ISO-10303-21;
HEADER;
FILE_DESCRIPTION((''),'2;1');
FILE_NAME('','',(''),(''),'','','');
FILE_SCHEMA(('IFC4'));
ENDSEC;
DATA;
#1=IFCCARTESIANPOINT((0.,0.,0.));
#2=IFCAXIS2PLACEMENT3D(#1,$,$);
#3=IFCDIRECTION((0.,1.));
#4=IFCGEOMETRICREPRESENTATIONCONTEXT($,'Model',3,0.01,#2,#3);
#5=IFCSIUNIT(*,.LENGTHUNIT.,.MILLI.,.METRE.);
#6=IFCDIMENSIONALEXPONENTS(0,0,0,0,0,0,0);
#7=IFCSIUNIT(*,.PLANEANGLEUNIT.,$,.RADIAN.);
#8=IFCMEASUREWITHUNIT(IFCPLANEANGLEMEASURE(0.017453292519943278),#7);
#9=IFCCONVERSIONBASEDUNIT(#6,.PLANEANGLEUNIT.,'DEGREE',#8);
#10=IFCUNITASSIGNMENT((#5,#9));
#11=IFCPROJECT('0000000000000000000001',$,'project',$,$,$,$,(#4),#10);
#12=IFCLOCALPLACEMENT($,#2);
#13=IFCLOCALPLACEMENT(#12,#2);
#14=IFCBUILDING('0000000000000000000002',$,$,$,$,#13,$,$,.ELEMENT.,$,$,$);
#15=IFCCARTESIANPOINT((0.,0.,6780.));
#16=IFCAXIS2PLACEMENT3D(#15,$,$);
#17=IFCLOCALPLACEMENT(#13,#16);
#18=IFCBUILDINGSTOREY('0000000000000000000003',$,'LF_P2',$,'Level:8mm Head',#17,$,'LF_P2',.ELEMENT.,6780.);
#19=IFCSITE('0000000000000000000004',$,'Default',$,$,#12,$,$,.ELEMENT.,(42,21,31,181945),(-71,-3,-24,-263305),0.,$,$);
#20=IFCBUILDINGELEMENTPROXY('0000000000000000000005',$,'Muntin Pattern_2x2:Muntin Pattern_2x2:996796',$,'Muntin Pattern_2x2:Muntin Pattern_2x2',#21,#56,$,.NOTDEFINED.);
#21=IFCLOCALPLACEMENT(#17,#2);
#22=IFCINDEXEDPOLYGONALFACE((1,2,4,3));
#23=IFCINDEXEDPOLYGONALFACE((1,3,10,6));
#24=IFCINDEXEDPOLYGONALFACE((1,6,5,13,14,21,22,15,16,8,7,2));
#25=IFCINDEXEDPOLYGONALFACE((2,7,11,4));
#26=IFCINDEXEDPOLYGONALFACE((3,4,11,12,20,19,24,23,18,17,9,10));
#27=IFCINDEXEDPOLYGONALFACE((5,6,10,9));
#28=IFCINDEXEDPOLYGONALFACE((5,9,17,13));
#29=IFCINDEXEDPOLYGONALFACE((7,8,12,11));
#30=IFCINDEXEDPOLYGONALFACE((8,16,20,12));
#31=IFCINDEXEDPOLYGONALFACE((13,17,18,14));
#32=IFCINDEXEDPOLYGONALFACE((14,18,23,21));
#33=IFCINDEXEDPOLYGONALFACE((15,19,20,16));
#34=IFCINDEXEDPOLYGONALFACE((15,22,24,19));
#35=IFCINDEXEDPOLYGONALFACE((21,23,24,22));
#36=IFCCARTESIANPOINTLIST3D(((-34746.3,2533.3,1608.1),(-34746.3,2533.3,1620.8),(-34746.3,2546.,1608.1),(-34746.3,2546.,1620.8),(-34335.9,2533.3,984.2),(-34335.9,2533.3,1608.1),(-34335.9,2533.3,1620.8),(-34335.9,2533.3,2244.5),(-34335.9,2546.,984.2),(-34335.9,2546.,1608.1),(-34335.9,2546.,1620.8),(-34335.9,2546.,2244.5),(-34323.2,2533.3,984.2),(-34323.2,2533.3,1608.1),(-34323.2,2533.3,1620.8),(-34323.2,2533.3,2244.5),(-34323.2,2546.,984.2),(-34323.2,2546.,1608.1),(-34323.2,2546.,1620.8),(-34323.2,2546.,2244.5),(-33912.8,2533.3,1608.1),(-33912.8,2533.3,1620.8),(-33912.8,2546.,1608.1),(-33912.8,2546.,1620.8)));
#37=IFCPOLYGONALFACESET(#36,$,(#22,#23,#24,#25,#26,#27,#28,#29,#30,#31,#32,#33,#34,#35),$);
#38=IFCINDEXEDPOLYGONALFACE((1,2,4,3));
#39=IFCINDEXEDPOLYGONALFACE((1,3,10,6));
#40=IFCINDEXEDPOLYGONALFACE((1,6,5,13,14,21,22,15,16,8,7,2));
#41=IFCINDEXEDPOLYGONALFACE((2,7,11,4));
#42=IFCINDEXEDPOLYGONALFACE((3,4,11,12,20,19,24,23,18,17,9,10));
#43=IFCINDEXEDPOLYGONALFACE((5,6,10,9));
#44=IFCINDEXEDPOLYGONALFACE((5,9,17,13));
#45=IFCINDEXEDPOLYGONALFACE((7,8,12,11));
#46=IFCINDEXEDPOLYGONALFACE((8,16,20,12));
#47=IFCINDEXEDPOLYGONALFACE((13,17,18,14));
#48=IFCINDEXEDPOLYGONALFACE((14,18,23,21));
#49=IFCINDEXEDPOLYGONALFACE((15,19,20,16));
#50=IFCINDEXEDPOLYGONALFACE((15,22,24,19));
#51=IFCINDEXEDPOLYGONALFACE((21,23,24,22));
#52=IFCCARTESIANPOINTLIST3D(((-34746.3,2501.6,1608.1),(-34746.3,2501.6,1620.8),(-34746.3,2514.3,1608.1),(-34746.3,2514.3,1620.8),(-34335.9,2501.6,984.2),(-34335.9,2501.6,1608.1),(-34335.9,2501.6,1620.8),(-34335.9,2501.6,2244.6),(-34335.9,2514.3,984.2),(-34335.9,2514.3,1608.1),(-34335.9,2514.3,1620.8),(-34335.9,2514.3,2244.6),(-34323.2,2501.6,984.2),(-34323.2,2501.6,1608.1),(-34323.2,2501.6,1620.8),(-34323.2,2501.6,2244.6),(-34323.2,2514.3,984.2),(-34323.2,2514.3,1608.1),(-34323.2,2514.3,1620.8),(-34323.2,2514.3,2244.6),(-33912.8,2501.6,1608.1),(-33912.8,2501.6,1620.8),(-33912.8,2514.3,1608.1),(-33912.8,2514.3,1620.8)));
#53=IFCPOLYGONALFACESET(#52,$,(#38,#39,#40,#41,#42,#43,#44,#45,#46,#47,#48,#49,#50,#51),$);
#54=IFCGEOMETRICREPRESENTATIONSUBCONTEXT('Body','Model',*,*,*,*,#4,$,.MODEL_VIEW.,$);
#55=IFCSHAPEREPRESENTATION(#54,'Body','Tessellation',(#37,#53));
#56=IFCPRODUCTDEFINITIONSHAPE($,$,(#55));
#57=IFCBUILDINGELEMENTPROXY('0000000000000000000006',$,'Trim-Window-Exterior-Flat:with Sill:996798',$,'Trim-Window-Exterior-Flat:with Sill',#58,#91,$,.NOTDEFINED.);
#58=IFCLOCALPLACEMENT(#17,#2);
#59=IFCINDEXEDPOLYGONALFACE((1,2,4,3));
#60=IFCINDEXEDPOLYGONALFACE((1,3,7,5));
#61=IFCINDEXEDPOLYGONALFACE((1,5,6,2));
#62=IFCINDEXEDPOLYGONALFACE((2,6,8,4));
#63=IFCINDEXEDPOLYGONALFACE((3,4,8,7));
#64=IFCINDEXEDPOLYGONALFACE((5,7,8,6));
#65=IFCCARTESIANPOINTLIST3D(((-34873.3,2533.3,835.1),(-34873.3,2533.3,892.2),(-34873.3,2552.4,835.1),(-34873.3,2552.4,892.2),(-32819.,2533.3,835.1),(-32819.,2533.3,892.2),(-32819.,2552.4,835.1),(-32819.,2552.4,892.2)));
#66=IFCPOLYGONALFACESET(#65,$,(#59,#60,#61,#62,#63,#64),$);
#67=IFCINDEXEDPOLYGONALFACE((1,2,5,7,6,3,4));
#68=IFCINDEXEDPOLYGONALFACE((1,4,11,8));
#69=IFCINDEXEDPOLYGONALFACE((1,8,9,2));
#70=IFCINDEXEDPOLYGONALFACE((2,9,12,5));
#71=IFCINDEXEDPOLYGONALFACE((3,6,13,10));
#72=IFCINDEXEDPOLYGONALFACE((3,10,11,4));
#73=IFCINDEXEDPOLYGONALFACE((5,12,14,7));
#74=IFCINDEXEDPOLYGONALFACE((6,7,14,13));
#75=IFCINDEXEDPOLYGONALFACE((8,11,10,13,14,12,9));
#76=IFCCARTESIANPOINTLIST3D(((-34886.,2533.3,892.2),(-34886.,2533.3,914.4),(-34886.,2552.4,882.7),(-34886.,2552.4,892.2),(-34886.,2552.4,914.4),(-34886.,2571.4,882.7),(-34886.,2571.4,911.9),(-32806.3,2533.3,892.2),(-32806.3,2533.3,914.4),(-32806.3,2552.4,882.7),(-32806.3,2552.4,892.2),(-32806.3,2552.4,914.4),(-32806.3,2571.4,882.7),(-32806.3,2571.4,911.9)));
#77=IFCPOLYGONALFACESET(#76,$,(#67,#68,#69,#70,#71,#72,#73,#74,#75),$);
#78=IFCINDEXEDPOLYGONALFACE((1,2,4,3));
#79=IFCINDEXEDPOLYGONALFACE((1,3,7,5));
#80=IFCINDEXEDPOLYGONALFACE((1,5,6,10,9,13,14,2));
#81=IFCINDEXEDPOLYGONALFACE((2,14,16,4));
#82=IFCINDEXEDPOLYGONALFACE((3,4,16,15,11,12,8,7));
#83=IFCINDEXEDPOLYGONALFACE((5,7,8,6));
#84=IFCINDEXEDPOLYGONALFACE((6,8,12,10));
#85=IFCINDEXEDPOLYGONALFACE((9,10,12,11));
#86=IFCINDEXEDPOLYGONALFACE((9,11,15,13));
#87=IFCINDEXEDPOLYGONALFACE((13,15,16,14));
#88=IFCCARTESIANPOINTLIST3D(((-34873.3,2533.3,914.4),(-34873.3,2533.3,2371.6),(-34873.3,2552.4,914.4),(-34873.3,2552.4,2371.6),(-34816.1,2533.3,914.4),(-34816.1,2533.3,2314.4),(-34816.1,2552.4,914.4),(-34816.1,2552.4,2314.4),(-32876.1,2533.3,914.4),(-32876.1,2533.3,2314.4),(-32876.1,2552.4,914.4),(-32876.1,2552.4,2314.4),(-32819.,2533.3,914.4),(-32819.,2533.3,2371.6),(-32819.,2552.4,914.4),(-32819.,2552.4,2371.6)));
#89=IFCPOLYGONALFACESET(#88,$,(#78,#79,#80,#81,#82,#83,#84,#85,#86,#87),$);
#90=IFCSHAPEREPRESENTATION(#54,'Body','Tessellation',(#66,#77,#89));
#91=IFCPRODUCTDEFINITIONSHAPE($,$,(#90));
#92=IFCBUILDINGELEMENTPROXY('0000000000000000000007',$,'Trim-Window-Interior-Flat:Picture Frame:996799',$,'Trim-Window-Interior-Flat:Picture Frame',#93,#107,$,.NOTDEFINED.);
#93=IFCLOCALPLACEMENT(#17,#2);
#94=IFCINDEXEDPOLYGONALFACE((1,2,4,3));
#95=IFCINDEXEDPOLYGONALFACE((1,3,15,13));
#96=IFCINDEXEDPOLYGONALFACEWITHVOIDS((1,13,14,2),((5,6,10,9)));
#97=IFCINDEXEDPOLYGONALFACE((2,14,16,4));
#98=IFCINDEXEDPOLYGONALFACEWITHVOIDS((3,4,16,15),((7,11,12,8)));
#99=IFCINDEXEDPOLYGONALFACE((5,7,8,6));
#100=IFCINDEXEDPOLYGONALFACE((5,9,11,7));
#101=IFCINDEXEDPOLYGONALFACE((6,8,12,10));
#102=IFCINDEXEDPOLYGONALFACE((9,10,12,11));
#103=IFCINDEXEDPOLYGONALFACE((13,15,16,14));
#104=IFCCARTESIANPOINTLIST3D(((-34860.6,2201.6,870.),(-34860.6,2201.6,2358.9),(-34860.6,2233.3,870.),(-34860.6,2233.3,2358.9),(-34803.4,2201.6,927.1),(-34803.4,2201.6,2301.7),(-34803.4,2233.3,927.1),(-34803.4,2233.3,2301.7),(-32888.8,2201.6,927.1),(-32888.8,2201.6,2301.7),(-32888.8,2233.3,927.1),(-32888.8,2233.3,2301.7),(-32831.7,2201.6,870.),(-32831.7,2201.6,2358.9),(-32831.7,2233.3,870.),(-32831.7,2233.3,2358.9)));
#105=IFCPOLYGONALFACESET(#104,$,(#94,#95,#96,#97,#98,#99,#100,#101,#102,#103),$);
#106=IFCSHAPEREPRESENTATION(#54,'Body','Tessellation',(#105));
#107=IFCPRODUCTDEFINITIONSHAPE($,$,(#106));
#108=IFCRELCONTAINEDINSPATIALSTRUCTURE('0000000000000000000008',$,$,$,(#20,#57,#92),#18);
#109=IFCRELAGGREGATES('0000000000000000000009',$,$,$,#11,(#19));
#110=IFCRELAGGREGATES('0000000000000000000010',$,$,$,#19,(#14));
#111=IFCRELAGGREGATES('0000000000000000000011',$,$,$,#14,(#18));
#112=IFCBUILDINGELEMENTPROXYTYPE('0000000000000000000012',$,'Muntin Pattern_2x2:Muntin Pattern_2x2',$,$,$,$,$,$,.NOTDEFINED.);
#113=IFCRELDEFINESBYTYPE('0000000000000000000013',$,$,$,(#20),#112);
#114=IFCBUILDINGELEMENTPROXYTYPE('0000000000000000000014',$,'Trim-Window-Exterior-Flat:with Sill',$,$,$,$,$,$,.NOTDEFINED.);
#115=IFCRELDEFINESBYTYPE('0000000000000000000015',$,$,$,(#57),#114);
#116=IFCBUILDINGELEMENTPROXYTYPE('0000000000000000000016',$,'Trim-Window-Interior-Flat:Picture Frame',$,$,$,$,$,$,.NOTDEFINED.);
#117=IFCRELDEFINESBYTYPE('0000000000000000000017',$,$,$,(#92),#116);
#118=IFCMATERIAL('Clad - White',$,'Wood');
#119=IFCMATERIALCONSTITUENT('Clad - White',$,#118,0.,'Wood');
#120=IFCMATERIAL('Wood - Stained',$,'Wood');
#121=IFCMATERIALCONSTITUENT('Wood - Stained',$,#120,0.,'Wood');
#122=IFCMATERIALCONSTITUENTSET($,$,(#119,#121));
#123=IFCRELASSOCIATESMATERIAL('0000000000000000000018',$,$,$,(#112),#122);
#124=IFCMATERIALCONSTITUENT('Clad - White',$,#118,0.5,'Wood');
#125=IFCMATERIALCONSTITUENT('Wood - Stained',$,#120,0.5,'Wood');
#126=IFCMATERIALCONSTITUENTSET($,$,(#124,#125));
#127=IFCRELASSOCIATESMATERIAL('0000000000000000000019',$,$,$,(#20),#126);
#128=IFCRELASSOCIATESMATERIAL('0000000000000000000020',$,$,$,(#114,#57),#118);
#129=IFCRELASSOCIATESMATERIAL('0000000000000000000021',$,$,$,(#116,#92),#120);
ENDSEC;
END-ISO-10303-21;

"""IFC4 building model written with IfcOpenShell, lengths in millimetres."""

from ifc_helpers import new_model, entity, si_unit, converted_unit, direction, frame, origin, place, context, subcontext, project, spatial, indexed_curve, outline, extrude, source, transform, mapped, material, constituent, constituent_set, type_object, type_shapes, element, save


model = new_model("IFC4")

# Units and contexts
model_context = context("Model", 3, precision=0.01, world=origin(), true_north=direction((0.0, 1.0)))
body_context = subcontext(model_context, "Body", "Model", "MODEL_VIEW")
ifc_project = project(units=[si_unit("LENGTHUNIT", "METRE", prefix="MILLI"), converted_unit("PLANEANGLEUNIT", "DEGREE", entity("IfcPlaneAngleMeasure", 0.017453292519943278), si_unit("PLANEANGLEUNIT", "RADIAN"), dimensions=[0, 0, 0, 0, 0, 0, 0])], contexts=[model_context])

# Site, building, storey
site_placement = place(None, origin())
site = spatial("IfcSite", under=ifc_project, at=site_placement, Name="Default", CompositionType="ELEMENT", RefLatitude=(42, 21, 31, 181945), RefLongitude=(-71, -3, -24, -263305), RefElevation=0.0)
building_placement = place(site_placement, origin())
building = spatial("IfcBuilding", under=site, at=building_placement, CompositionType="ELEMENT")
storey_placement = place(building_placement, frame((0.0, 0.0, 6780.0)))
storey = spatial("IfcBuildingStorey", under=building, at=storey_placement, Name="LF_P2", ObjectType="Level:8mm Head", LongName="LF_P2", CompositionType="ELEMENT", Elevation=6780.0)

# Building element proxies
ifc_material_1 = material(Name="Clad - White", Category="Wood")
ifc_material_2 = material(Name="Wood - Stained", Category="Wood")
ifc_constituent_1 = constituent(ifc_material_1, Name="Clad - White", Category="Wood", fraction=0.0)
ifc_constituent_2 = constituent(ifc_material_2, Name="Wood - Stained", Category="Wood", fraction=0.0)
ifc_constituent_set_1 = constituent_set(constituents=[ifc_constituent_1, ifc_constituent_2])
building_element_proxy_type_1 = type_object("IfcBuildingElementProxyType", Name="Muntin Pattern_2x2:Muntin Pattern_2x2", PredefinedType="NOTDEFINED", material=ifc_constituent_set_1)
shared_shape_1 = source(origin(), body_context, "Body", "SweptSolid", [
    extrude(outline(indexed_curve([(6.4, -6.4), (630.1, -6.4), (630.1, 6.3), (6.4, 6.3), (6.4, 416.7), (-6.3, 416.7), (-6.3, 6.3), (-630.2, 6.3), (-630.2, -6.4), (-6.3, -6.4), (-6.3, -416.7), (6.4, -416.7), (6.4, -6.4)], self_intersect=False)), frame((0.0, 9.5, 630.1), z_axis=(0.0, 1.0, 0.0), x_axis=(0.0, 0.0, 1.0)), (0.0, 0.0, 1.0), 12.7),
    extrude(outline(indexed_curve([(6.4, -6.4), (630.2, -6.4), (630.2, 6.3), (6.4, 6.3), (6.4, 416.7), (-6.3, 416.7), (-6.3, 6.3), (-630.2, 6.3), (-630.2, -6.4), (-6.3, -6.4), (-6.3, -416.7), (6.4, -416.7), (6.4, -6.4)], self_intersect=False)), frame((0.0, -22.2, 630.2), z_axis=(0.0, 1.0, 0.0), x_axis=(0.0, 0.0, 1.0)), (0.0, 0.0, 1.0), 12.7),
])
type_shapes(building_element_proxy_type_1, [shared_shape_1])
ifc_constituent_3 = constituent(ifc_material_1, Name="Clad - White", Category="Wood", fraction=0.5)
ifc_constituent_4 = constituent(ifc_material_2, Name="Wood - Stained", Category="Wood", fraction=0.5)
ifc_constituent_set_2 = constituent_set(constituents=[ifc_constituent_3, ifc_constituent_4])
proxy_1_placement = place(storey_placement, frame((-34329.5, 2523.8, 984.3)))
element("IfcBuildingElementProxy", 1, at=proxy_1_placement, inside=storey, type_object=building_element_proxy_type_1, material=ifc_constituent_set_2, Name="Muntin Pattern_2x2:Muntin Pattern_2x2:996796", ObjectType="Muntin Pattern_2x2:Muntin Pattern_2x2", PredefinedType="NOTDEFINED", context=body_context, shape_type="MappedRepresentation", body=[
    mapped(shared_shape_1, transform((0.0, 0.0, 0.0), scale=1.0)),
])
building_element_proxy_type_2 = type_object("IfcBuildingElementProxyType", Name="Trim-Window-Exterior-Flat:with Sill", PredefinedType="NOTDEFINED", material=ifc_material_1)
shared_shape_2 = source(origin(), body_context, "Body", "SweptSolid", [
    extrude(outline(indexed_curve([(-1027.1, -28.6), (1027.1, -28.6), (1027.1, 28.6), (-1027.1, 28.6), (-1027.1, -28.6)], self_intersect=False)), frame((0.0, -1450.8, 0.0), z_axis=(0.0, 0.0, 1.0), x_axis=(-1.0, 0.0, 0.0)), (0.0, 0.0, 1.0), 19.0),
    extrude(outline(indexed_curve([(-19.0, -16.0), (0.0, -16.0), (0.0, -6.4), (19.0, -6.4), (19.0, 15.8), (0.0, 15.8), (-19.0, 13.3), (-19.0, -16.0)], self_intersect=False)), frame((-1039.8, -1415.8, 19.0), z_axis=(1.0, 0.0, 0.0), x_axis=(0.0, 0.0, -1.0)), (0.0, 0.0, 1.0), 2079.7),
    extrude(outline(indexed_curve([(-742.9, -1027.1), (714.3, -1027.1), (714.3, -970.0), (-685.7, -970.0), (-685.7, 970.0), (714.3, 970.0), (714.3, 1027.1), (-742.9, 1027.1), (-742.9, -1027.1)], self_intersect=False)), frame((0.0, -685.7, 0.0), z_axis=(0.0, 0.0, 1.0), x_axis=(0.0, -1.0, 0.0)), (0.0, 0.0, 1.0), 19.0),
])
type_shapes(building_element_proxy_type_2, [shared_shape_2])
proxy_2_placement = place(storey_placement, frame((-33846.1, 2533.3, 2314.4), z_axis=(0.0, 1.0, 0.0), x_axis=(-1.0, 0.0, 0.0)))
element("IfcBuildingElementProxy", 2, at=proxy_2_placement, inside=storey, type_object=building_element_proxy_type_2, material=ifc_material_1, Name="Trim-Window-Exterior-Flat:with Sill:996798", ObjectType="Trim-Window-Exterior-Flat:with Sill", PredefinedType="NOTDEFINED", context=body_context, shape_type="MappedRepresentation", body=[
    mapped(shared_shape_2, transform((0.0, 0.0, 0.0), scale=1.0)),
])
building_element_proxy_type_3 = type_object("IfcBuildingElementProxyType", Name="Trim-Window-Interior-Flat:Picture Frame", PredefinedType="NOTDEFINED", material=ifc_material_2)
shared_shape_3 = source(origin(), body_context, "Body", "SweptSolid", [
    extrude(outline(indexed_curve([(-1014.4, -744.4), (1014.4, -744.4), (1014.4, 744.4), (-1014.4, 744.4), (-1014.4, -744.4)], self_intersect=False), holes=[indexed_curve([(-957.3, -687.3), (-957.3, 687.3), (957.3, 687.3), (957.3, -687.3), (-957.3, -687.3)], self_intersect=False)]), frame((0.0, -700.0, 0.0), z_axis=(0.0, 0.0, 1.0), x_axis=(-1.0, 0.0, 0.0)), (0.0, 0.0, 1.0), 31.7),
])
type_shapes(building_element_proxy_type_3, [shared_shape_3])
proxy_3_placement = place(storey_placement, frame((-33846.1, 2233.3, 2314.4), z_axis=(0.0, -1.0, 0.0), x_axis=(1.0, 0.0, 0.0)))
element("IfcBuildingElementProxy", 3, at=proxy_3_placement, inside=storey, type_object=building_element_proxy_type_3, material=ifc_material_2, Name="Trim-Window-Interior-Flat:Picture Frame:996799", ObjectType="Trim-Window-Interior-Flat:Picture Frame", PredefinedType="NOTDEFINED", context=body_context, shape_type="MappedRepresentation", body=[
    mapped(shared_shape_3, transform((0.0, 0.0, 0.0), scale=1.0)),
])

save(model, "model.ifc")
